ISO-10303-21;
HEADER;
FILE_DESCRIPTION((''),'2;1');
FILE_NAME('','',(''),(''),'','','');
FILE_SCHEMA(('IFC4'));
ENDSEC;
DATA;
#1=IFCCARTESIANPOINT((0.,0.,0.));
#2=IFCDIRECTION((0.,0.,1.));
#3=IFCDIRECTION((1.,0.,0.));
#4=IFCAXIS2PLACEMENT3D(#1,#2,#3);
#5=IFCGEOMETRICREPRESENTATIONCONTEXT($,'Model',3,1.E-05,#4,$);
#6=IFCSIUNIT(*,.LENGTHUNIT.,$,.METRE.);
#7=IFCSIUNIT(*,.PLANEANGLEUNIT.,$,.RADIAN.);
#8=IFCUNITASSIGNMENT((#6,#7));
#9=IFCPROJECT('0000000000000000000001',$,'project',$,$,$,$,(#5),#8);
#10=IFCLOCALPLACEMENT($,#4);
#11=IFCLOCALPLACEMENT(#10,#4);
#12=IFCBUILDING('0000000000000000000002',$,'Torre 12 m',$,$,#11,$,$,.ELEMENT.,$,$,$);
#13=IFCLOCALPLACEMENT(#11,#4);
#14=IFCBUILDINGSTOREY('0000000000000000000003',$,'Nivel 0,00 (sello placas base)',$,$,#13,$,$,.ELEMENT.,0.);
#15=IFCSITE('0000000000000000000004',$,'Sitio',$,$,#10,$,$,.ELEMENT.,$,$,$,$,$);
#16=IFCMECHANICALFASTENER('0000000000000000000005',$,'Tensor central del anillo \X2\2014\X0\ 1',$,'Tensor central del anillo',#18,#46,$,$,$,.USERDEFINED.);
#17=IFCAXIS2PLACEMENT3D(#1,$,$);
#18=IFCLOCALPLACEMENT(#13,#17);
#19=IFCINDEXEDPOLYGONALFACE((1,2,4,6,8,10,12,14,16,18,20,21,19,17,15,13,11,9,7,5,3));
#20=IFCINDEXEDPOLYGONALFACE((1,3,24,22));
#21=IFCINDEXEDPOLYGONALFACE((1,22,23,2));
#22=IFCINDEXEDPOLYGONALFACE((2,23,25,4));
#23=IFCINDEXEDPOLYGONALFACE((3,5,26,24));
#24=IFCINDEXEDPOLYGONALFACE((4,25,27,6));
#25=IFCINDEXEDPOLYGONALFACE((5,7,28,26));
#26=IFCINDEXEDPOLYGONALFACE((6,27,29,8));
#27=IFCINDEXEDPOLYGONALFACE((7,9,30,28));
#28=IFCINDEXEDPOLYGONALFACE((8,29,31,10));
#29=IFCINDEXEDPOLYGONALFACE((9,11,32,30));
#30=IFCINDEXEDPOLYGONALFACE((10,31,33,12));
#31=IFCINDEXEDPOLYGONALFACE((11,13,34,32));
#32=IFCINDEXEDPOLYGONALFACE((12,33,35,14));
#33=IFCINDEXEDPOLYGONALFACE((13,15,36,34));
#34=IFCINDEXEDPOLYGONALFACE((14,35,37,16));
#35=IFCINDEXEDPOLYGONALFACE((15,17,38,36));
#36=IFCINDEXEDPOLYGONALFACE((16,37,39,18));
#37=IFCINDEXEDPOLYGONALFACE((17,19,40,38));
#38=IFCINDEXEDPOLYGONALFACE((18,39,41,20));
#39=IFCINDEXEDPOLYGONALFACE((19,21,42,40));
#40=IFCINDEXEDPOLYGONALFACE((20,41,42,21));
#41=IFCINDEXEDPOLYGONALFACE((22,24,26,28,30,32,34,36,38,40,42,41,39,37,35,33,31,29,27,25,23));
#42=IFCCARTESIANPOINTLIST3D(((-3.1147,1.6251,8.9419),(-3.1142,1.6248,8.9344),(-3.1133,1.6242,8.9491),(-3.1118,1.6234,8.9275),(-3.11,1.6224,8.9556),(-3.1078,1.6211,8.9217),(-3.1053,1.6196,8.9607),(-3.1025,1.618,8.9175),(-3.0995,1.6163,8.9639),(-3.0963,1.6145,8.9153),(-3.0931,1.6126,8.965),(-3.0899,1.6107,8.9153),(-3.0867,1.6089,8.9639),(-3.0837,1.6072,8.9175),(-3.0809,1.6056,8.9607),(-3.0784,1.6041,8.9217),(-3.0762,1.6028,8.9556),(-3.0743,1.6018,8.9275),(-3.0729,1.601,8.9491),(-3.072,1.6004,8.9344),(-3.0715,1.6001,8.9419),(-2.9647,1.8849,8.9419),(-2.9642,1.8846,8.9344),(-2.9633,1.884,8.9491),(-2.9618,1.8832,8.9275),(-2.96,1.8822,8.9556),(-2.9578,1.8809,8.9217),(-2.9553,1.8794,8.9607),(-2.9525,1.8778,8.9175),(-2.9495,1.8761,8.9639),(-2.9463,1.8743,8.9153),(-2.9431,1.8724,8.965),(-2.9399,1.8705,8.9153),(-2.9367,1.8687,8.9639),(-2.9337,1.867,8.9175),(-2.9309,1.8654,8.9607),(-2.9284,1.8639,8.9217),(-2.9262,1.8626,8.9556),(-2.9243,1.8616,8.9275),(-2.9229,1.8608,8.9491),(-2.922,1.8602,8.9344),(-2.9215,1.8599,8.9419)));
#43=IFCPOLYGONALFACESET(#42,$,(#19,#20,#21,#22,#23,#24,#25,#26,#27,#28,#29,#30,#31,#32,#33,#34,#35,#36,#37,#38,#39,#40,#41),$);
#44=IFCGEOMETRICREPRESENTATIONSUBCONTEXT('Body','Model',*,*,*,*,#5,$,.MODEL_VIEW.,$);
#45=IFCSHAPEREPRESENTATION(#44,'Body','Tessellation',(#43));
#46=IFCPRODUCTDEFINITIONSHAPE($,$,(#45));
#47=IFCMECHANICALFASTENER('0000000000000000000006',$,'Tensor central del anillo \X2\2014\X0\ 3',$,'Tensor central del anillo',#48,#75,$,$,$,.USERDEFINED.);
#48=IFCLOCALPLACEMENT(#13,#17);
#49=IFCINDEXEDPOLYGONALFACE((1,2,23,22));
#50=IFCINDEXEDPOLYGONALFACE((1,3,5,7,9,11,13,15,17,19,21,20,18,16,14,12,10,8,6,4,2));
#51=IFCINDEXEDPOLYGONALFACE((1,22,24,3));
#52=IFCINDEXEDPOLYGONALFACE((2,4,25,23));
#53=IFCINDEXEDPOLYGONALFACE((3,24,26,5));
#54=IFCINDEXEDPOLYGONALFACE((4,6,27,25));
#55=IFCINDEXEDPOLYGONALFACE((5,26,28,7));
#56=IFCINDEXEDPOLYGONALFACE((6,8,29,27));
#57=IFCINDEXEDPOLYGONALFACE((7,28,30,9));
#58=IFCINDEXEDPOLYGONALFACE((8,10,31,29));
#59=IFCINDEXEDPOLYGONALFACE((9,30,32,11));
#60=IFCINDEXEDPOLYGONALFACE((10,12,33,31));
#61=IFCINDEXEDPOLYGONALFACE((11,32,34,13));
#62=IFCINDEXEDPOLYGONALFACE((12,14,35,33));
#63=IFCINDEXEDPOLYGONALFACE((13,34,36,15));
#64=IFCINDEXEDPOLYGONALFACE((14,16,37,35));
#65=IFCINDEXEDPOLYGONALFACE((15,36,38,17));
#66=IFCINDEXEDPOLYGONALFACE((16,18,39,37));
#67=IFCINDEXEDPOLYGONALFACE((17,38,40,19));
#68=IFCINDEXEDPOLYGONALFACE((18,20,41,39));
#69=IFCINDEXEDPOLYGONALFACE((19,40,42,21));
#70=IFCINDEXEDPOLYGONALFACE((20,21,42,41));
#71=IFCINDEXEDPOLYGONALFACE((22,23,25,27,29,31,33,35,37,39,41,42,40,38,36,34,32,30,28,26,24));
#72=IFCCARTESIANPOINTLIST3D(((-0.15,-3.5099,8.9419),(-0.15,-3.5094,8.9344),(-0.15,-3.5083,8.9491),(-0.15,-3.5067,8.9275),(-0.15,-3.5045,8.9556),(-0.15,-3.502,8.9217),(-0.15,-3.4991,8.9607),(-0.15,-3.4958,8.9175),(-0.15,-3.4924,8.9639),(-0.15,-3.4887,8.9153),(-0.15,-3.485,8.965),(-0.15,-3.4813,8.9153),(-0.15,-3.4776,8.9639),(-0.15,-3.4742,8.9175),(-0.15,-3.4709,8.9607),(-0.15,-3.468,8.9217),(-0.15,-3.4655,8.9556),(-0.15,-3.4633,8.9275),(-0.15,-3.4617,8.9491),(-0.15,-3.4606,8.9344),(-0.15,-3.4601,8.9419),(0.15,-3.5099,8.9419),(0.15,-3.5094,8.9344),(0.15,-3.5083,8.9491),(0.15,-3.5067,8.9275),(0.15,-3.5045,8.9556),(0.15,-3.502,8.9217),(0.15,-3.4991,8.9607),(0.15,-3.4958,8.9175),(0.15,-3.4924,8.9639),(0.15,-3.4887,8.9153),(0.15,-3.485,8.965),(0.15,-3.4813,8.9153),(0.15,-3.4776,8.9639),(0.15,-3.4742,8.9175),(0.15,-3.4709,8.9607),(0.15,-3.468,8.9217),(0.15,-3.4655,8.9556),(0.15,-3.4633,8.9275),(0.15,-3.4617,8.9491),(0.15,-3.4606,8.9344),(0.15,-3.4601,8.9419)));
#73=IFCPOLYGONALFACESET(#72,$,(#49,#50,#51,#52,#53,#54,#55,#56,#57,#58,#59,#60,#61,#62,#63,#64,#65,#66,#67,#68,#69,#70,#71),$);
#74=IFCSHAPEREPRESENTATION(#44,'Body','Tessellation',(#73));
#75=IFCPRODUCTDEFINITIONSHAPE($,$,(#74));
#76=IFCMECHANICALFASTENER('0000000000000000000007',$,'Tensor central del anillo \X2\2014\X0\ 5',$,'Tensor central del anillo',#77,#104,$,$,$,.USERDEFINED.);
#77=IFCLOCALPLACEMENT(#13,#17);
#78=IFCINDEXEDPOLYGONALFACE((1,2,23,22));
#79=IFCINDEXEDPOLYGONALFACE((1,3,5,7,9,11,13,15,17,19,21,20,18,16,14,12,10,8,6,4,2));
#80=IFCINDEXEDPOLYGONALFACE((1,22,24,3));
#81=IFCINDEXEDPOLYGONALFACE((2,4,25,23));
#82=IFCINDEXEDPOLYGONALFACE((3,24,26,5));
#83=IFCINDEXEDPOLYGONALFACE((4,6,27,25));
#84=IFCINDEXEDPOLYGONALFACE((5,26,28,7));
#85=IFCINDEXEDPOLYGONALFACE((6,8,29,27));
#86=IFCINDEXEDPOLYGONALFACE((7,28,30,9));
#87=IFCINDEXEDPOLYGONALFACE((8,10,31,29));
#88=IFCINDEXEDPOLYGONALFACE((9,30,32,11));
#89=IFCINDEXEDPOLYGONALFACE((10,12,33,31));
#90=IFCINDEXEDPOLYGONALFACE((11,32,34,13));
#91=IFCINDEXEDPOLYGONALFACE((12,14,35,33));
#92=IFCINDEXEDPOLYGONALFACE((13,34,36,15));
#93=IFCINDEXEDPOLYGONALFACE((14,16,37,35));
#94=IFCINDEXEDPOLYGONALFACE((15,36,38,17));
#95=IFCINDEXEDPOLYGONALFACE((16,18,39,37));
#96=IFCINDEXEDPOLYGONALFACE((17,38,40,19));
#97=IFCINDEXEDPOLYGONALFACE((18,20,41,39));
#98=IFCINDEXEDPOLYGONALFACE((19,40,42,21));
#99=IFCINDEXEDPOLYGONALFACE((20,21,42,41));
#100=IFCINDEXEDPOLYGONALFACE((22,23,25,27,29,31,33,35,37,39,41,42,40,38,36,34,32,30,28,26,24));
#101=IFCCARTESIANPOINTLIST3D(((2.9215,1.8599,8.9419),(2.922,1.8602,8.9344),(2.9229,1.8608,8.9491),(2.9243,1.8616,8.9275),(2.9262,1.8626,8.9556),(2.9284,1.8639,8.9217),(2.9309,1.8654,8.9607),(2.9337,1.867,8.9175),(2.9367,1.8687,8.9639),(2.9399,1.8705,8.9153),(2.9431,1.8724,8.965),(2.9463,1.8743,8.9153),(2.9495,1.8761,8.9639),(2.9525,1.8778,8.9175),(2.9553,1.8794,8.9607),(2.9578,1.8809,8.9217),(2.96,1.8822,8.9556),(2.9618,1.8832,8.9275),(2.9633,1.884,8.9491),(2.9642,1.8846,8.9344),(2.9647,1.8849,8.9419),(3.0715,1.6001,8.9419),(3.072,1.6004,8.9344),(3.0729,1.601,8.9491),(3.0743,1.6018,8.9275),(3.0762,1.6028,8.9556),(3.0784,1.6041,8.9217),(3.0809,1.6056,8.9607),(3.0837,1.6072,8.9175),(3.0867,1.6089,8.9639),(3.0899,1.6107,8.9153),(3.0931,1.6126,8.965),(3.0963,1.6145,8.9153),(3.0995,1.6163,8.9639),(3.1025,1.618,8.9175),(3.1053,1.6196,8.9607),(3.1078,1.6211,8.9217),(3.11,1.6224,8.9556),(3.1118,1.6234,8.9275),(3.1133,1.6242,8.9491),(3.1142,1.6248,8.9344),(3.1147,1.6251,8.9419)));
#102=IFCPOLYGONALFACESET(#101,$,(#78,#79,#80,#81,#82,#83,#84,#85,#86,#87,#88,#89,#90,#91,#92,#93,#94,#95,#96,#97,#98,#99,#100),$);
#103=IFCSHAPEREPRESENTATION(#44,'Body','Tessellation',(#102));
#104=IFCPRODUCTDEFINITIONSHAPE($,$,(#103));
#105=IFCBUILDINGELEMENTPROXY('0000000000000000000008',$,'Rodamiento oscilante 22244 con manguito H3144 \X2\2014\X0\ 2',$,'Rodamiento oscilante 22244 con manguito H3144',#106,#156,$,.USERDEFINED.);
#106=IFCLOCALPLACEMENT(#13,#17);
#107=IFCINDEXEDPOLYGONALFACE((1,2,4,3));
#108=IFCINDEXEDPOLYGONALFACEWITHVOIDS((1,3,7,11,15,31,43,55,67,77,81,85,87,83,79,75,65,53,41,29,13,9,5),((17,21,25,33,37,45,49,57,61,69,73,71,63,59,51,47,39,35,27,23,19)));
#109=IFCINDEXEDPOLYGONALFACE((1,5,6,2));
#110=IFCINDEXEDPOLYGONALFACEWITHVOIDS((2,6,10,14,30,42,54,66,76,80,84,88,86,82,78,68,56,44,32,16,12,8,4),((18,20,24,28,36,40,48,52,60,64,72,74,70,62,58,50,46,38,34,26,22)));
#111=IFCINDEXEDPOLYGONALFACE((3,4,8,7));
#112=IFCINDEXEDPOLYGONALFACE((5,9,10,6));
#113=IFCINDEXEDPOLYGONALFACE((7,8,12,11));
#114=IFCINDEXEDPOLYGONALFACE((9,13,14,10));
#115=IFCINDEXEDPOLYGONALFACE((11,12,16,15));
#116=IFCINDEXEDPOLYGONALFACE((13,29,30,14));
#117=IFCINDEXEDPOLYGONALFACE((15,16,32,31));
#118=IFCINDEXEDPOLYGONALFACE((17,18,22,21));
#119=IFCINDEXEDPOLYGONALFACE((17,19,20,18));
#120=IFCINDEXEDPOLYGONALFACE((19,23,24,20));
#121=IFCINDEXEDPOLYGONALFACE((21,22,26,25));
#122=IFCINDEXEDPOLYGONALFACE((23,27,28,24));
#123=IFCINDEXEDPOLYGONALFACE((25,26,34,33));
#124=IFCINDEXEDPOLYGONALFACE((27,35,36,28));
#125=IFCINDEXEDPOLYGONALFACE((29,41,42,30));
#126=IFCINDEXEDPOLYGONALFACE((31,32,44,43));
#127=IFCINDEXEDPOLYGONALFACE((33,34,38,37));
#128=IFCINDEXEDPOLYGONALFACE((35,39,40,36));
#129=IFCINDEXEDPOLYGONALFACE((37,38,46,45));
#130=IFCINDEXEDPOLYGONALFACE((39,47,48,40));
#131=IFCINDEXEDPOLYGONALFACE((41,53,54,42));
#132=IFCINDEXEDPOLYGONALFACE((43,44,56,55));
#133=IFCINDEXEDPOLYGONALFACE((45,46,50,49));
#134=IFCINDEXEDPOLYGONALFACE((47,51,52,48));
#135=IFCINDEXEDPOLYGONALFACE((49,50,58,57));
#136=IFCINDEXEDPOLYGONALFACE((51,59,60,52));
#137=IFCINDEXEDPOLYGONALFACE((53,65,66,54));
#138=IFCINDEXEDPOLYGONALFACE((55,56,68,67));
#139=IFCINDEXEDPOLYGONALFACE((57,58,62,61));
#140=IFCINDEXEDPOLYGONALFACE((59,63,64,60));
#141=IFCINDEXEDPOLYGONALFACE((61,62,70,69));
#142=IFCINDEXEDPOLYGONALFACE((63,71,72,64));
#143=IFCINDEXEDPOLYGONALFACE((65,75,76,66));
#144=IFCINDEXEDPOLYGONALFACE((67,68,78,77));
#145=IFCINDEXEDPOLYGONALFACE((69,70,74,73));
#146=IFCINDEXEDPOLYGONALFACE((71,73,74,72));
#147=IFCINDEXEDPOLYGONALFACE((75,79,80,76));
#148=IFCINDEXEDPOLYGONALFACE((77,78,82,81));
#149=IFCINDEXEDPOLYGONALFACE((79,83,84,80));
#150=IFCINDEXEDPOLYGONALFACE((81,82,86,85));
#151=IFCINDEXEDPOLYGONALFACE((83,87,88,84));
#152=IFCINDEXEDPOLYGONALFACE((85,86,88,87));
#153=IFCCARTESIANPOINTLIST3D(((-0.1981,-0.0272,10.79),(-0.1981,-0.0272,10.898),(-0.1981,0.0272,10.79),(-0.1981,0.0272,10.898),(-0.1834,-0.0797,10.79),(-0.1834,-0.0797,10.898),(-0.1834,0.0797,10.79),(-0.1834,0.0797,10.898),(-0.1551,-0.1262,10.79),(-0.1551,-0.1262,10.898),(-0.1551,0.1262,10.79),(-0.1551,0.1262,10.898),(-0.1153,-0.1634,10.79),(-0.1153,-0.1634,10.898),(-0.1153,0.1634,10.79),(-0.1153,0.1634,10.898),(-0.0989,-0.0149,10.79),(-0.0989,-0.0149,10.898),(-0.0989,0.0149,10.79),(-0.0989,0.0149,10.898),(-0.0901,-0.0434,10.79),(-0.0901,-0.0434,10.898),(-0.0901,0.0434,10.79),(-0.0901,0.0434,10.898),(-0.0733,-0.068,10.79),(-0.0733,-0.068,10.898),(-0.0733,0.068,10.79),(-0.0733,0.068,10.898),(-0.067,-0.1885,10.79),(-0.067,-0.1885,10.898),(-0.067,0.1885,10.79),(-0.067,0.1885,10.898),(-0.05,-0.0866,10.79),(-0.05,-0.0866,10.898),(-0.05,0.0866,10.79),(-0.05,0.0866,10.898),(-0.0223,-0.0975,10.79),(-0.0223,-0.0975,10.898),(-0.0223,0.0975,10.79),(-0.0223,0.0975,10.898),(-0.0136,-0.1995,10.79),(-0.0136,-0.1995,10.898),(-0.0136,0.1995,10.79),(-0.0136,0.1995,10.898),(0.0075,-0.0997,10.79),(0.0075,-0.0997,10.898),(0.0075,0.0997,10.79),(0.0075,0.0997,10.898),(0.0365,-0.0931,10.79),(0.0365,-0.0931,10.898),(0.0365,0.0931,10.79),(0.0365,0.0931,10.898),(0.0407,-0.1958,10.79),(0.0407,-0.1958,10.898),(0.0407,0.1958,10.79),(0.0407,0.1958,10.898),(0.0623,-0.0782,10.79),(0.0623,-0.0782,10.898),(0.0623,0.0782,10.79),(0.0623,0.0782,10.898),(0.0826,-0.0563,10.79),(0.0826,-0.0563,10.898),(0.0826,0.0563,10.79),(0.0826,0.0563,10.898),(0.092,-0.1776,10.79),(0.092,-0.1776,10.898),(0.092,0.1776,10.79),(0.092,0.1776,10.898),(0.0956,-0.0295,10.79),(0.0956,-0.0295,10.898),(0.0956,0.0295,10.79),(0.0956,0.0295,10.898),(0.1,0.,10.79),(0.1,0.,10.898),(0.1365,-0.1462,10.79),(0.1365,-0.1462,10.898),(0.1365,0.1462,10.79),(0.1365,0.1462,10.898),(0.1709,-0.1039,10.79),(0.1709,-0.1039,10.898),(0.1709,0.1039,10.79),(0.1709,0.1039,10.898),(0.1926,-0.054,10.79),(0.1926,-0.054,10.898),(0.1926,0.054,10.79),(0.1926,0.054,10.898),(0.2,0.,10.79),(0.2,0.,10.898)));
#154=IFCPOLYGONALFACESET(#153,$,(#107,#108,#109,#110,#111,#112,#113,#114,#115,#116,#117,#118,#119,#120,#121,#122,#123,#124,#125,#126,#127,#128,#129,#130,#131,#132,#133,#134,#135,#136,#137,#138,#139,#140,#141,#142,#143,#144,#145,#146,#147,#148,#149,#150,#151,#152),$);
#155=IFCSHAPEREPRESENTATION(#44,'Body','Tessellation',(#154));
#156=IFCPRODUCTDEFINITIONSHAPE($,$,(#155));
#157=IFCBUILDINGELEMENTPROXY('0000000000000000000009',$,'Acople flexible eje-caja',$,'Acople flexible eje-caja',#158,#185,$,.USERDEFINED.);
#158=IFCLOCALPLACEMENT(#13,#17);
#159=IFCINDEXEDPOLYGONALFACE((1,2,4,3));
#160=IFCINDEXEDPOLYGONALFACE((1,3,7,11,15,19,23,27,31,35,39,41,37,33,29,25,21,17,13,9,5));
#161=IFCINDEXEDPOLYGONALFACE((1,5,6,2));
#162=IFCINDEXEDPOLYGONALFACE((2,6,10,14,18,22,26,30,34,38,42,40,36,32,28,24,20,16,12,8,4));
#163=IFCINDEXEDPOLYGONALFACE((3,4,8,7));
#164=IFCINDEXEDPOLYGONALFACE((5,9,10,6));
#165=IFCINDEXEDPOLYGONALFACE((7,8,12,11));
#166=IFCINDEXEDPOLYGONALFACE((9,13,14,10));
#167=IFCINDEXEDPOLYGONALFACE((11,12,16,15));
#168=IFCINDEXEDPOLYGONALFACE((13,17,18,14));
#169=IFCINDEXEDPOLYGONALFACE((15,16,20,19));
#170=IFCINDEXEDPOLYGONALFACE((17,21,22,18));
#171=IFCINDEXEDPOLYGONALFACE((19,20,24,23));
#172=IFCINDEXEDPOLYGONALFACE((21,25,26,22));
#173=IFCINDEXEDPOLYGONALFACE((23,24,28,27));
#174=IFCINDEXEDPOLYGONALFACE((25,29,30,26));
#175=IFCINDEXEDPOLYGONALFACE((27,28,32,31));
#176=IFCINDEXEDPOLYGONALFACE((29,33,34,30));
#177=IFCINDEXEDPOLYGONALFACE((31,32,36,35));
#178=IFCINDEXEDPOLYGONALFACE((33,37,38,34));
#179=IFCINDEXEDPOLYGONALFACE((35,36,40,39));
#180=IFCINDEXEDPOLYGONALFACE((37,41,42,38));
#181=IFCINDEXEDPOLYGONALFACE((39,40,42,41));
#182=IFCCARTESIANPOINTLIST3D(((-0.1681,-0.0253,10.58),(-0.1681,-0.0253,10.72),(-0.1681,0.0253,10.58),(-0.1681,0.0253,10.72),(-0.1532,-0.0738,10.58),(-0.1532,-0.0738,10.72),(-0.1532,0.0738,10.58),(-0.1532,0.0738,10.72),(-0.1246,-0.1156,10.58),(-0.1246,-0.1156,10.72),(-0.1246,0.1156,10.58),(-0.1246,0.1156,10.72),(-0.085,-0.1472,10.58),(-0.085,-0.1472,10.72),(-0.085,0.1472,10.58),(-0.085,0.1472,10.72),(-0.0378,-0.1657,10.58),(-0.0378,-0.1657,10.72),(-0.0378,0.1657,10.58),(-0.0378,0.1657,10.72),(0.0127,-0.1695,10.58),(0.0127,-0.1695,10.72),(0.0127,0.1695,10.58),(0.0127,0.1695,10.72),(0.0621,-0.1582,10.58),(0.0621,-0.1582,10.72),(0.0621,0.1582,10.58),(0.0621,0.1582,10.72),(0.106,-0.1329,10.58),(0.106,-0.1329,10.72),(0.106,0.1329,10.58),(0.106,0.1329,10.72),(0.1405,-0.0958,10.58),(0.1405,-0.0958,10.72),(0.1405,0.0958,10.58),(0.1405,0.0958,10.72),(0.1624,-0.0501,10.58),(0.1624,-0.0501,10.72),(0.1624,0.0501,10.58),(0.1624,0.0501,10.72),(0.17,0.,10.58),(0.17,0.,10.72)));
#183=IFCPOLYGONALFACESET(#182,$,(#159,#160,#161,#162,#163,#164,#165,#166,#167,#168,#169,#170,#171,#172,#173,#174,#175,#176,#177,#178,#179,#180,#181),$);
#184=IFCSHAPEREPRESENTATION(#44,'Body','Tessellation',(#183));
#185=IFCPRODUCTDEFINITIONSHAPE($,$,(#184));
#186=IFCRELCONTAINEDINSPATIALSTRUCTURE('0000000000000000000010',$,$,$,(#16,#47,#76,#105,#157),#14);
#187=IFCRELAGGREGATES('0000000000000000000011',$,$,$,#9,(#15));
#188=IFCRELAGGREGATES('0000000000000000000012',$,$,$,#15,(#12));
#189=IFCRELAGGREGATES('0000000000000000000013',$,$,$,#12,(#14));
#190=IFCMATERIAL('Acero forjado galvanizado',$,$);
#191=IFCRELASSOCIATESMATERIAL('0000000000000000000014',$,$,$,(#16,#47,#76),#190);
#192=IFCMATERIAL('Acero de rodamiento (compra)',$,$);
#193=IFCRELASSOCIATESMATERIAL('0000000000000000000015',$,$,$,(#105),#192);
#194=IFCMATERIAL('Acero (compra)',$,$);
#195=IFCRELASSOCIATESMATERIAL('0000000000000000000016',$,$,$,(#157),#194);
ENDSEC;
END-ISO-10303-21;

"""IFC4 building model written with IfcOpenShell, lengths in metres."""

from ifc_helpers import new_model, si_unit, frame, origin, origin_with_axes, origin_2d, place, context, subcontext, project, spatial, circle, hollow_circle, extrude, material, element, save


model = new_model("IFC4")

# Units and contexts
model_context = context("Model", 3, precision=1e-05, world=origin_with_axes())
body_context = subcontext(model_context, "Body", "Model", "MODEL_VIEW")
ifc_project = project(units=[si_unit("LENGTHUNIT", "METRE"), si_unit("PLANEANGLEUNIT", "RADIAN")], contexts=[model_context])

# Site, building, storey
site_placement = place(None, origin_with_axes())
site = spatial("IfcSite", under=ifc_project, at=site_placement, Name="Sitio", CompositionType="ELEMENT")
building_placement = place(site_placement, origin_with_axes())
building = spatial("IfcBuilding", under=site, at=building_placement, Name="Torre 12 m", CompositionType="ELEMENT")
storey_placement = place(building_placement, origin_with_axes())
storey = spatial("IfcBuildingStorey", under=building, at=storey_placement, Name="Nivel 0,00 (sello placas base)", CompositionType="ELEMENT", Elevation=0.0)

# Mechanical fasteners
ifc_material_1 = material(Name="Acero forjado galvanizado")
for number, where, z_axis, x_axis, name in (
    (1, (-2.9431, 1.8724, 8.94), (-0.5, -0.866025, 0.0), (0.0, 0.0, 1.0), "Tensor central del anillo — 1"),
    (2, (-0.15, -3.485, 8.94), (1.0, 0.0, 0.0), (0.0, 0.0, 1.0), "Tensor central del anillo — 3"),
    (3, (3.0931, 1.6126, 8.94), (-0.5, 0.866025, 0.0), (0.0, 0.0, 1.0), "Tensor central del anillo — 5"),
):
    element("IfcMechanicalFastener", number, at=place(storey_placement, frame(where, z_axis=z_axis, x_axis=x_axis)), inside=storey, material=ifc_material_1, Name=name, ObjectType="Tensor central del anillo", PredefinedType="USERDEFINED", context=body_context, shape_type="SweptSolid", body=[
        extrude(circle(Radius=0.025, at=origin_2d()), origin(), (0.0, 0.0, 1.0), 0.3),
    ])

# Building element proxies
ifc_material_2 = material(Name="Acero de rodamiento (compra)")
proxy_1_placement = place(storey_placement, frame((0.0, 0.0, 10.79), z_axis=(0.0, 0.0, 1.0), x_axis=(1.0, 0.0, 0.0)))
element("IfcBuildingElementProxy", 4, at=proxy_1_placement, inside=storey, material=ifc_material_2, Name="Rodamiento oscilante 22244 con manguito H3144 — 2", ObjectType="Rodamiento oscilante 22244 con manguito H3144", PredefinedType="USERDEFINED", context=body_context, shape_type="SweptSolid", body=[
    extrude(hollow_circle(Radius=0.2, WallThickness=0.1, at=origin_2d()), origin(), (0.0, 0.0, 1.0), 0.108),
])
ifc_material_3 = material(Name="Acero (compra)")
proxy_2_placement = place(storey_placement, frame((0.0, 0.0, 10.58), z_axis=(0.0, 0.0, 1.0), x_axis=(1.0, 0.0, 0.0)))
element("IfcBuildingElementProxy", 5, at=proxy_2_placement, inside=storey, material=ifc_material_3, Name="Acople flexible eje-caja", ObjectType="Acople flexible eje-caja", PredefinedType="USERDEFINED", context=body_context, shape_type="SweptSolid", body=[
    extrude(circle(Radius=0.17, at=origin_2d()), origin(), (0.0, 0.0, 1.0), 0.14),
])

save(model, "model.ifc")
